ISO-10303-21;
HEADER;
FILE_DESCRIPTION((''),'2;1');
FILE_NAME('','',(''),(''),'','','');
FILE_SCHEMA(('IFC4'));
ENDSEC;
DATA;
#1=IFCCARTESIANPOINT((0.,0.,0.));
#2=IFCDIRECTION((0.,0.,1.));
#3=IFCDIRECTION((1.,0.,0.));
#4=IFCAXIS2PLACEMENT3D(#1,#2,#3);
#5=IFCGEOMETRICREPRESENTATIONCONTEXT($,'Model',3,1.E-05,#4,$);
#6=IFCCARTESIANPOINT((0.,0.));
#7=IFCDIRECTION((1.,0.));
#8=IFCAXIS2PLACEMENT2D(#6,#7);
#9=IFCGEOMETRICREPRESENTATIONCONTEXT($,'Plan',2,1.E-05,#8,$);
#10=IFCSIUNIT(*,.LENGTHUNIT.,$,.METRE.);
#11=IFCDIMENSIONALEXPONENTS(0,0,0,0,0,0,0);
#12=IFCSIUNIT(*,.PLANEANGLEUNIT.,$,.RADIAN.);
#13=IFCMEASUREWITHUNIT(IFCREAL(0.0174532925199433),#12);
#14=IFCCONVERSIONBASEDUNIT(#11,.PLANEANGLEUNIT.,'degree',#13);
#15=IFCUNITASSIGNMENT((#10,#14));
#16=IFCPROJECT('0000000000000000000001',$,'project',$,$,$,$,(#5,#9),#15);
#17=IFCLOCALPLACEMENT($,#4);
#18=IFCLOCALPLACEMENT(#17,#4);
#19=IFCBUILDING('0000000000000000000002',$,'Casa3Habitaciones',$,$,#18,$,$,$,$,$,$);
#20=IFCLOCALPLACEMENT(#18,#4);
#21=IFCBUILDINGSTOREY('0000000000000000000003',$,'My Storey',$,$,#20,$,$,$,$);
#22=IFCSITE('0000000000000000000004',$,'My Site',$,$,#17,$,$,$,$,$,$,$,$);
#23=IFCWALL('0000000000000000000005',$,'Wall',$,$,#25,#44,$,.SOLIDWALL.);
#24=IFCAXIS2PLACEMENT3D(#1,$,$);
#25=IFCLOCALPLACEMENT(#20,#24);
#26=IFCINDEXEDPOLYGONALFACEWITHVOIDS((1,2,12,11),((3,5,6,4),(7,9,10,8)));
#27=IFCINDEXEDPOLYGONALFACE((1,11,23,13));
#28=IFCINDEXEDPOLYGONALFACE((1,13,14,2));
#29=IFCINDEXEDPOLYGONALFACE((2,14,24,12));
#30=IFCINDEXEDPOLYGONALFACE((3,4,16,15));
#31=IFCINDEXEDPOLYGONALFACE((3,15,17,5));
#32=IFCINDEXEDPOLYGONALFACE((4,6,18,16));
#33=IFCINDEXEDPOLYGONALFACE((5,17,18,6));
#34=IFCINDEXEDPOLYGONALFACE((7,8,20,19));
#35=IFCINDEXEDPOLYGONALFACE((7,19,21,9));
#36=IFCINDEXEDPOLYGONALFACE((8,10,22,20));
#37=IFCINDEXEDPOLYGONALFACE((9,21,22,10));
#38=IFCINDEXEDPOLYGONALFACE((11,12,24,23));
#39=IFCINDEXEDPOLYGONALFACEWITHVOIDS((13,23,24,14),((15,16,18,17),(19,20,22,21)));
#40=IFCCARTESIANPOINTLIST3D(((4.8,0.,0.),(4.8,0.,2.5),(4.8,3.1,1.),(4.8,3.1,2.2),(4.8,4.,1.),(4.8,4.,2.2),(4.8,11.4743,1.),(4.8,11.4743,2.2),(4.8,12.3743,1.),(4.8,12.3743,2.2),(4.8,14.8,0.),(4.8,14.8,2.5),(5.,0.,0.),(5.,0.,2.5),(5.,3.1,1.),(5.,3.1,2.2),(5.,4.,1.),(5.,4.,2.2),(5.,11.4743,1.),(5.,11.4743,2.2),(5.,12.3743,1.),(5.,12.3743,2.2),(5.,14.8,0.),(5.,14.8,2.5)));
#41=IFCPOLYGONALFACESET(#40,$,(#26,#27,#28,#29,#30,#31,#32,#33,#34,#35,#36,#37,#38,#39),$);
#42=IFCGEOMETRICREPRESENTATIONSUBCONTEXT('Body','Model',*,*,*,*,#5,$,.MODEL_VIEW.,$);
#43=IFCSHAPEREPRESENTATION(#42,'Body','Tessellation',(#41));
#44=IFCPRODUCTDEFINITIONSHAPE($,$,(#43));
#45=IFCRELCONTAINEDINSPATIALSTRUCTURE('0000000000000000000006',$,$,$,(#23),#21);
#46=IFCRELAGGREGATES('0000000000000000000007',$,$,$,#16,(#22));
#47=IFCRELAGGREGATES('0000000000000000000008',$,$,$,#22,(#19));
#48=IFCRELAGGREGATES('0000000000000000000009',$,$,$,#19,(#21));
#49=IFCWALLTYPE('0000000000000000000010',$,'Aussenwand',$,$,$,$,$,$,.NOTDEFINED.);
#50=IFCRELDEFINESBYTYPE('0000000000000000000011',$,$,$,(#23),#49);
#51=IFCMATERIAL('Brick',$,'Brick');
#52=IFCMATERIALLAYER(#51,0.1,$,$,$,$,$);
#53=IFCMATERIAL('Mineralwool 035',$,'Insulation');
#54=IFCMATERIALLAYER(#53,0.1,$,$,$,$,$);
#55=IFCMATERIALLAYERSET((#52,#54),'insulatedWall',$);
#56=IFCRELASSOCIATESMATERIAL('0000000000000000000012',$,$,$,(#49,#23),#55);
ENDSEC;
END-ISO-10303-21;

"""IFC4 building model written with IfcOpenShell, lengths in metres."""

from ifc_helpers import new_model, entity, si_unit, converted_unit, frame, origin_with_axes, origin_2d_with_axis, place, context, subcontext, project, spatial, line, indexed_curve, outline, extrude, source, transform, mapped, material, layer, layer_set, layer_usage, type_object, element, save


model = new_model("IFC4")

# Units and contexts
model_context = context("Model", 3, precision=1e-05, world=origin_with_axes())
plan_context = context("Plan", 2, precision=1e-05, world=origin_2d_with_axis())
body_context = subcontext(model_context, "Body", "Model", "MODEL_VIEW")
ifc_project = project(units=[si_unit("LENGTHUNIT", "METRE"), converted_unit("PLANEANGLEUNIT", "degree", entity("IfcReal", 0.0174532925199433), si_unit("PLANEANGLEUNIT", "RADIAN"), dimensions=[0, 0, 0, 0, 0, 0, 0])], contexts=[model_context, plan_context])

# Site, building, storey
site_placement = place(None, origin_with_axes())
site = spatial("IfcSite", under=ifc_project, at=site_placement, Name="My Site")
building_placement = place(site_placement, origin_with_axes())
building = spatial("IfcBuilding", under=site, at=building_placement, Name="Casa3Habitaciones")
storey_placement = place(building_placement, origin_with_axes())
storey = spatial("IfcBuildingStorey", under=building, at=storey_placement, Name="My Storey")

# Shared definitions
ifc_material_1 = material(Name="Brick", Category="Brick")

# Shared definitions
ifc_layer_1 = layer(ifc_material_1, 0.1)
ifc_material_2 = material(Name="Mineralwool 035", Category="Insulation")
ifc_layer_2 = layer(ifc_material_2, 0.1)
ifc_layer_set_1 = layer_set([ifc_layer_1, ifc_layer_2], Name="insulatedWall")
wall_type_1 = type_object("IfcWallType", Name="Aussenwand", PredefinedType="NOTDEFINED", material=ifc_layer_set_1)
shared_shape_1 = source(origin_with_axes(), body_context, "Body", "SweptSolid", [
    extrude(outline(indexed_curve([(0.0, 0.0), (0.9, 0.0), (0.9, 1.2), (0.0, 1.2)], segments=[line(1, 2, 3, 4, 1)])), frame((0.0, -0.6, 0.0), z_axis=(0.0, -1.0, 0.0), x_axis=(1.0, 0.0, 0.0)), (0.0, 0.0, -1.0), 1.2),
])

# Wall, openings
ifc_layer_usage_1 = layer_usage(ifc_layer_set_1, "AXIS2", "POSITIVE", 0.0)
wall_1_placement = place(storey_placement, frame((5.0, 0.0, 0.0), z_axis=(0.0, 0.0, 1.0), x_axis=(0.000001, 1.0, 0.0)))
wall_1 = element("IfcWall", 1, at=wall_1_placement, inside=storey, type_object=wall_type_1, material=ifc_layer_usage_1, Name="Wall", PredefinedType="SOLIDWALL", context=body_context, shape_type="SweptSolid", body=[
    extrude(outline(indexed_curve([(0.0, 0.0), (0.0, 0.2), (14.8, 0.2), (14.8, 0.0), (0.0, 0.0)], self_intersect=False)), origin_with_axes(), (0.0, 0.0, 1.0), 2.5),
])
opening_1_placement = place(wall_1_placement, frame((3.1, 0.0, 1.0), z_axis=(0.0, 0.0, 1.0), x_axis=(1.0, 0.0, 0.0)))
element("IfcOpeningElement", 2, at=opening_1_placement, cuts=wall_1, PredefinedType="OPENING", context=body_context, shape_type="MappedRepresentation", body=[
    mapped(shared_shape_1, transform((0.0, 0.0, 0.0), x_axis=(1.0, 0.0, 0.0), y_axis=(0.0, 1.0, 0.0), z_axis=(0.0, 0.0, 1.0), scale=1.0)),
])
opening_2_placement = place(wall_1_placement, frame((11.4743, 0.0, 1.0), z_axis=(0.0, 0.0, 1.0), x_axis=(1.0, 0.0, 0.0)))
element("IfcOpeningElement", 3, at=opening_2_placement, cuts=wall_1, PredefinedType="OPENING", context=body_context, shape_type="MappedRepresentation", body=[
    mapped(shared_shape_1, transform((0.0, 0.0, 0.0), x_axis=(1.0, 0.0, 0.0), y_axis=(0.0, 1.0, 0.0), z_axis=(0.0, 0.0, 1.0), scale=1.0)),
])

save(model, "model.ifc")
